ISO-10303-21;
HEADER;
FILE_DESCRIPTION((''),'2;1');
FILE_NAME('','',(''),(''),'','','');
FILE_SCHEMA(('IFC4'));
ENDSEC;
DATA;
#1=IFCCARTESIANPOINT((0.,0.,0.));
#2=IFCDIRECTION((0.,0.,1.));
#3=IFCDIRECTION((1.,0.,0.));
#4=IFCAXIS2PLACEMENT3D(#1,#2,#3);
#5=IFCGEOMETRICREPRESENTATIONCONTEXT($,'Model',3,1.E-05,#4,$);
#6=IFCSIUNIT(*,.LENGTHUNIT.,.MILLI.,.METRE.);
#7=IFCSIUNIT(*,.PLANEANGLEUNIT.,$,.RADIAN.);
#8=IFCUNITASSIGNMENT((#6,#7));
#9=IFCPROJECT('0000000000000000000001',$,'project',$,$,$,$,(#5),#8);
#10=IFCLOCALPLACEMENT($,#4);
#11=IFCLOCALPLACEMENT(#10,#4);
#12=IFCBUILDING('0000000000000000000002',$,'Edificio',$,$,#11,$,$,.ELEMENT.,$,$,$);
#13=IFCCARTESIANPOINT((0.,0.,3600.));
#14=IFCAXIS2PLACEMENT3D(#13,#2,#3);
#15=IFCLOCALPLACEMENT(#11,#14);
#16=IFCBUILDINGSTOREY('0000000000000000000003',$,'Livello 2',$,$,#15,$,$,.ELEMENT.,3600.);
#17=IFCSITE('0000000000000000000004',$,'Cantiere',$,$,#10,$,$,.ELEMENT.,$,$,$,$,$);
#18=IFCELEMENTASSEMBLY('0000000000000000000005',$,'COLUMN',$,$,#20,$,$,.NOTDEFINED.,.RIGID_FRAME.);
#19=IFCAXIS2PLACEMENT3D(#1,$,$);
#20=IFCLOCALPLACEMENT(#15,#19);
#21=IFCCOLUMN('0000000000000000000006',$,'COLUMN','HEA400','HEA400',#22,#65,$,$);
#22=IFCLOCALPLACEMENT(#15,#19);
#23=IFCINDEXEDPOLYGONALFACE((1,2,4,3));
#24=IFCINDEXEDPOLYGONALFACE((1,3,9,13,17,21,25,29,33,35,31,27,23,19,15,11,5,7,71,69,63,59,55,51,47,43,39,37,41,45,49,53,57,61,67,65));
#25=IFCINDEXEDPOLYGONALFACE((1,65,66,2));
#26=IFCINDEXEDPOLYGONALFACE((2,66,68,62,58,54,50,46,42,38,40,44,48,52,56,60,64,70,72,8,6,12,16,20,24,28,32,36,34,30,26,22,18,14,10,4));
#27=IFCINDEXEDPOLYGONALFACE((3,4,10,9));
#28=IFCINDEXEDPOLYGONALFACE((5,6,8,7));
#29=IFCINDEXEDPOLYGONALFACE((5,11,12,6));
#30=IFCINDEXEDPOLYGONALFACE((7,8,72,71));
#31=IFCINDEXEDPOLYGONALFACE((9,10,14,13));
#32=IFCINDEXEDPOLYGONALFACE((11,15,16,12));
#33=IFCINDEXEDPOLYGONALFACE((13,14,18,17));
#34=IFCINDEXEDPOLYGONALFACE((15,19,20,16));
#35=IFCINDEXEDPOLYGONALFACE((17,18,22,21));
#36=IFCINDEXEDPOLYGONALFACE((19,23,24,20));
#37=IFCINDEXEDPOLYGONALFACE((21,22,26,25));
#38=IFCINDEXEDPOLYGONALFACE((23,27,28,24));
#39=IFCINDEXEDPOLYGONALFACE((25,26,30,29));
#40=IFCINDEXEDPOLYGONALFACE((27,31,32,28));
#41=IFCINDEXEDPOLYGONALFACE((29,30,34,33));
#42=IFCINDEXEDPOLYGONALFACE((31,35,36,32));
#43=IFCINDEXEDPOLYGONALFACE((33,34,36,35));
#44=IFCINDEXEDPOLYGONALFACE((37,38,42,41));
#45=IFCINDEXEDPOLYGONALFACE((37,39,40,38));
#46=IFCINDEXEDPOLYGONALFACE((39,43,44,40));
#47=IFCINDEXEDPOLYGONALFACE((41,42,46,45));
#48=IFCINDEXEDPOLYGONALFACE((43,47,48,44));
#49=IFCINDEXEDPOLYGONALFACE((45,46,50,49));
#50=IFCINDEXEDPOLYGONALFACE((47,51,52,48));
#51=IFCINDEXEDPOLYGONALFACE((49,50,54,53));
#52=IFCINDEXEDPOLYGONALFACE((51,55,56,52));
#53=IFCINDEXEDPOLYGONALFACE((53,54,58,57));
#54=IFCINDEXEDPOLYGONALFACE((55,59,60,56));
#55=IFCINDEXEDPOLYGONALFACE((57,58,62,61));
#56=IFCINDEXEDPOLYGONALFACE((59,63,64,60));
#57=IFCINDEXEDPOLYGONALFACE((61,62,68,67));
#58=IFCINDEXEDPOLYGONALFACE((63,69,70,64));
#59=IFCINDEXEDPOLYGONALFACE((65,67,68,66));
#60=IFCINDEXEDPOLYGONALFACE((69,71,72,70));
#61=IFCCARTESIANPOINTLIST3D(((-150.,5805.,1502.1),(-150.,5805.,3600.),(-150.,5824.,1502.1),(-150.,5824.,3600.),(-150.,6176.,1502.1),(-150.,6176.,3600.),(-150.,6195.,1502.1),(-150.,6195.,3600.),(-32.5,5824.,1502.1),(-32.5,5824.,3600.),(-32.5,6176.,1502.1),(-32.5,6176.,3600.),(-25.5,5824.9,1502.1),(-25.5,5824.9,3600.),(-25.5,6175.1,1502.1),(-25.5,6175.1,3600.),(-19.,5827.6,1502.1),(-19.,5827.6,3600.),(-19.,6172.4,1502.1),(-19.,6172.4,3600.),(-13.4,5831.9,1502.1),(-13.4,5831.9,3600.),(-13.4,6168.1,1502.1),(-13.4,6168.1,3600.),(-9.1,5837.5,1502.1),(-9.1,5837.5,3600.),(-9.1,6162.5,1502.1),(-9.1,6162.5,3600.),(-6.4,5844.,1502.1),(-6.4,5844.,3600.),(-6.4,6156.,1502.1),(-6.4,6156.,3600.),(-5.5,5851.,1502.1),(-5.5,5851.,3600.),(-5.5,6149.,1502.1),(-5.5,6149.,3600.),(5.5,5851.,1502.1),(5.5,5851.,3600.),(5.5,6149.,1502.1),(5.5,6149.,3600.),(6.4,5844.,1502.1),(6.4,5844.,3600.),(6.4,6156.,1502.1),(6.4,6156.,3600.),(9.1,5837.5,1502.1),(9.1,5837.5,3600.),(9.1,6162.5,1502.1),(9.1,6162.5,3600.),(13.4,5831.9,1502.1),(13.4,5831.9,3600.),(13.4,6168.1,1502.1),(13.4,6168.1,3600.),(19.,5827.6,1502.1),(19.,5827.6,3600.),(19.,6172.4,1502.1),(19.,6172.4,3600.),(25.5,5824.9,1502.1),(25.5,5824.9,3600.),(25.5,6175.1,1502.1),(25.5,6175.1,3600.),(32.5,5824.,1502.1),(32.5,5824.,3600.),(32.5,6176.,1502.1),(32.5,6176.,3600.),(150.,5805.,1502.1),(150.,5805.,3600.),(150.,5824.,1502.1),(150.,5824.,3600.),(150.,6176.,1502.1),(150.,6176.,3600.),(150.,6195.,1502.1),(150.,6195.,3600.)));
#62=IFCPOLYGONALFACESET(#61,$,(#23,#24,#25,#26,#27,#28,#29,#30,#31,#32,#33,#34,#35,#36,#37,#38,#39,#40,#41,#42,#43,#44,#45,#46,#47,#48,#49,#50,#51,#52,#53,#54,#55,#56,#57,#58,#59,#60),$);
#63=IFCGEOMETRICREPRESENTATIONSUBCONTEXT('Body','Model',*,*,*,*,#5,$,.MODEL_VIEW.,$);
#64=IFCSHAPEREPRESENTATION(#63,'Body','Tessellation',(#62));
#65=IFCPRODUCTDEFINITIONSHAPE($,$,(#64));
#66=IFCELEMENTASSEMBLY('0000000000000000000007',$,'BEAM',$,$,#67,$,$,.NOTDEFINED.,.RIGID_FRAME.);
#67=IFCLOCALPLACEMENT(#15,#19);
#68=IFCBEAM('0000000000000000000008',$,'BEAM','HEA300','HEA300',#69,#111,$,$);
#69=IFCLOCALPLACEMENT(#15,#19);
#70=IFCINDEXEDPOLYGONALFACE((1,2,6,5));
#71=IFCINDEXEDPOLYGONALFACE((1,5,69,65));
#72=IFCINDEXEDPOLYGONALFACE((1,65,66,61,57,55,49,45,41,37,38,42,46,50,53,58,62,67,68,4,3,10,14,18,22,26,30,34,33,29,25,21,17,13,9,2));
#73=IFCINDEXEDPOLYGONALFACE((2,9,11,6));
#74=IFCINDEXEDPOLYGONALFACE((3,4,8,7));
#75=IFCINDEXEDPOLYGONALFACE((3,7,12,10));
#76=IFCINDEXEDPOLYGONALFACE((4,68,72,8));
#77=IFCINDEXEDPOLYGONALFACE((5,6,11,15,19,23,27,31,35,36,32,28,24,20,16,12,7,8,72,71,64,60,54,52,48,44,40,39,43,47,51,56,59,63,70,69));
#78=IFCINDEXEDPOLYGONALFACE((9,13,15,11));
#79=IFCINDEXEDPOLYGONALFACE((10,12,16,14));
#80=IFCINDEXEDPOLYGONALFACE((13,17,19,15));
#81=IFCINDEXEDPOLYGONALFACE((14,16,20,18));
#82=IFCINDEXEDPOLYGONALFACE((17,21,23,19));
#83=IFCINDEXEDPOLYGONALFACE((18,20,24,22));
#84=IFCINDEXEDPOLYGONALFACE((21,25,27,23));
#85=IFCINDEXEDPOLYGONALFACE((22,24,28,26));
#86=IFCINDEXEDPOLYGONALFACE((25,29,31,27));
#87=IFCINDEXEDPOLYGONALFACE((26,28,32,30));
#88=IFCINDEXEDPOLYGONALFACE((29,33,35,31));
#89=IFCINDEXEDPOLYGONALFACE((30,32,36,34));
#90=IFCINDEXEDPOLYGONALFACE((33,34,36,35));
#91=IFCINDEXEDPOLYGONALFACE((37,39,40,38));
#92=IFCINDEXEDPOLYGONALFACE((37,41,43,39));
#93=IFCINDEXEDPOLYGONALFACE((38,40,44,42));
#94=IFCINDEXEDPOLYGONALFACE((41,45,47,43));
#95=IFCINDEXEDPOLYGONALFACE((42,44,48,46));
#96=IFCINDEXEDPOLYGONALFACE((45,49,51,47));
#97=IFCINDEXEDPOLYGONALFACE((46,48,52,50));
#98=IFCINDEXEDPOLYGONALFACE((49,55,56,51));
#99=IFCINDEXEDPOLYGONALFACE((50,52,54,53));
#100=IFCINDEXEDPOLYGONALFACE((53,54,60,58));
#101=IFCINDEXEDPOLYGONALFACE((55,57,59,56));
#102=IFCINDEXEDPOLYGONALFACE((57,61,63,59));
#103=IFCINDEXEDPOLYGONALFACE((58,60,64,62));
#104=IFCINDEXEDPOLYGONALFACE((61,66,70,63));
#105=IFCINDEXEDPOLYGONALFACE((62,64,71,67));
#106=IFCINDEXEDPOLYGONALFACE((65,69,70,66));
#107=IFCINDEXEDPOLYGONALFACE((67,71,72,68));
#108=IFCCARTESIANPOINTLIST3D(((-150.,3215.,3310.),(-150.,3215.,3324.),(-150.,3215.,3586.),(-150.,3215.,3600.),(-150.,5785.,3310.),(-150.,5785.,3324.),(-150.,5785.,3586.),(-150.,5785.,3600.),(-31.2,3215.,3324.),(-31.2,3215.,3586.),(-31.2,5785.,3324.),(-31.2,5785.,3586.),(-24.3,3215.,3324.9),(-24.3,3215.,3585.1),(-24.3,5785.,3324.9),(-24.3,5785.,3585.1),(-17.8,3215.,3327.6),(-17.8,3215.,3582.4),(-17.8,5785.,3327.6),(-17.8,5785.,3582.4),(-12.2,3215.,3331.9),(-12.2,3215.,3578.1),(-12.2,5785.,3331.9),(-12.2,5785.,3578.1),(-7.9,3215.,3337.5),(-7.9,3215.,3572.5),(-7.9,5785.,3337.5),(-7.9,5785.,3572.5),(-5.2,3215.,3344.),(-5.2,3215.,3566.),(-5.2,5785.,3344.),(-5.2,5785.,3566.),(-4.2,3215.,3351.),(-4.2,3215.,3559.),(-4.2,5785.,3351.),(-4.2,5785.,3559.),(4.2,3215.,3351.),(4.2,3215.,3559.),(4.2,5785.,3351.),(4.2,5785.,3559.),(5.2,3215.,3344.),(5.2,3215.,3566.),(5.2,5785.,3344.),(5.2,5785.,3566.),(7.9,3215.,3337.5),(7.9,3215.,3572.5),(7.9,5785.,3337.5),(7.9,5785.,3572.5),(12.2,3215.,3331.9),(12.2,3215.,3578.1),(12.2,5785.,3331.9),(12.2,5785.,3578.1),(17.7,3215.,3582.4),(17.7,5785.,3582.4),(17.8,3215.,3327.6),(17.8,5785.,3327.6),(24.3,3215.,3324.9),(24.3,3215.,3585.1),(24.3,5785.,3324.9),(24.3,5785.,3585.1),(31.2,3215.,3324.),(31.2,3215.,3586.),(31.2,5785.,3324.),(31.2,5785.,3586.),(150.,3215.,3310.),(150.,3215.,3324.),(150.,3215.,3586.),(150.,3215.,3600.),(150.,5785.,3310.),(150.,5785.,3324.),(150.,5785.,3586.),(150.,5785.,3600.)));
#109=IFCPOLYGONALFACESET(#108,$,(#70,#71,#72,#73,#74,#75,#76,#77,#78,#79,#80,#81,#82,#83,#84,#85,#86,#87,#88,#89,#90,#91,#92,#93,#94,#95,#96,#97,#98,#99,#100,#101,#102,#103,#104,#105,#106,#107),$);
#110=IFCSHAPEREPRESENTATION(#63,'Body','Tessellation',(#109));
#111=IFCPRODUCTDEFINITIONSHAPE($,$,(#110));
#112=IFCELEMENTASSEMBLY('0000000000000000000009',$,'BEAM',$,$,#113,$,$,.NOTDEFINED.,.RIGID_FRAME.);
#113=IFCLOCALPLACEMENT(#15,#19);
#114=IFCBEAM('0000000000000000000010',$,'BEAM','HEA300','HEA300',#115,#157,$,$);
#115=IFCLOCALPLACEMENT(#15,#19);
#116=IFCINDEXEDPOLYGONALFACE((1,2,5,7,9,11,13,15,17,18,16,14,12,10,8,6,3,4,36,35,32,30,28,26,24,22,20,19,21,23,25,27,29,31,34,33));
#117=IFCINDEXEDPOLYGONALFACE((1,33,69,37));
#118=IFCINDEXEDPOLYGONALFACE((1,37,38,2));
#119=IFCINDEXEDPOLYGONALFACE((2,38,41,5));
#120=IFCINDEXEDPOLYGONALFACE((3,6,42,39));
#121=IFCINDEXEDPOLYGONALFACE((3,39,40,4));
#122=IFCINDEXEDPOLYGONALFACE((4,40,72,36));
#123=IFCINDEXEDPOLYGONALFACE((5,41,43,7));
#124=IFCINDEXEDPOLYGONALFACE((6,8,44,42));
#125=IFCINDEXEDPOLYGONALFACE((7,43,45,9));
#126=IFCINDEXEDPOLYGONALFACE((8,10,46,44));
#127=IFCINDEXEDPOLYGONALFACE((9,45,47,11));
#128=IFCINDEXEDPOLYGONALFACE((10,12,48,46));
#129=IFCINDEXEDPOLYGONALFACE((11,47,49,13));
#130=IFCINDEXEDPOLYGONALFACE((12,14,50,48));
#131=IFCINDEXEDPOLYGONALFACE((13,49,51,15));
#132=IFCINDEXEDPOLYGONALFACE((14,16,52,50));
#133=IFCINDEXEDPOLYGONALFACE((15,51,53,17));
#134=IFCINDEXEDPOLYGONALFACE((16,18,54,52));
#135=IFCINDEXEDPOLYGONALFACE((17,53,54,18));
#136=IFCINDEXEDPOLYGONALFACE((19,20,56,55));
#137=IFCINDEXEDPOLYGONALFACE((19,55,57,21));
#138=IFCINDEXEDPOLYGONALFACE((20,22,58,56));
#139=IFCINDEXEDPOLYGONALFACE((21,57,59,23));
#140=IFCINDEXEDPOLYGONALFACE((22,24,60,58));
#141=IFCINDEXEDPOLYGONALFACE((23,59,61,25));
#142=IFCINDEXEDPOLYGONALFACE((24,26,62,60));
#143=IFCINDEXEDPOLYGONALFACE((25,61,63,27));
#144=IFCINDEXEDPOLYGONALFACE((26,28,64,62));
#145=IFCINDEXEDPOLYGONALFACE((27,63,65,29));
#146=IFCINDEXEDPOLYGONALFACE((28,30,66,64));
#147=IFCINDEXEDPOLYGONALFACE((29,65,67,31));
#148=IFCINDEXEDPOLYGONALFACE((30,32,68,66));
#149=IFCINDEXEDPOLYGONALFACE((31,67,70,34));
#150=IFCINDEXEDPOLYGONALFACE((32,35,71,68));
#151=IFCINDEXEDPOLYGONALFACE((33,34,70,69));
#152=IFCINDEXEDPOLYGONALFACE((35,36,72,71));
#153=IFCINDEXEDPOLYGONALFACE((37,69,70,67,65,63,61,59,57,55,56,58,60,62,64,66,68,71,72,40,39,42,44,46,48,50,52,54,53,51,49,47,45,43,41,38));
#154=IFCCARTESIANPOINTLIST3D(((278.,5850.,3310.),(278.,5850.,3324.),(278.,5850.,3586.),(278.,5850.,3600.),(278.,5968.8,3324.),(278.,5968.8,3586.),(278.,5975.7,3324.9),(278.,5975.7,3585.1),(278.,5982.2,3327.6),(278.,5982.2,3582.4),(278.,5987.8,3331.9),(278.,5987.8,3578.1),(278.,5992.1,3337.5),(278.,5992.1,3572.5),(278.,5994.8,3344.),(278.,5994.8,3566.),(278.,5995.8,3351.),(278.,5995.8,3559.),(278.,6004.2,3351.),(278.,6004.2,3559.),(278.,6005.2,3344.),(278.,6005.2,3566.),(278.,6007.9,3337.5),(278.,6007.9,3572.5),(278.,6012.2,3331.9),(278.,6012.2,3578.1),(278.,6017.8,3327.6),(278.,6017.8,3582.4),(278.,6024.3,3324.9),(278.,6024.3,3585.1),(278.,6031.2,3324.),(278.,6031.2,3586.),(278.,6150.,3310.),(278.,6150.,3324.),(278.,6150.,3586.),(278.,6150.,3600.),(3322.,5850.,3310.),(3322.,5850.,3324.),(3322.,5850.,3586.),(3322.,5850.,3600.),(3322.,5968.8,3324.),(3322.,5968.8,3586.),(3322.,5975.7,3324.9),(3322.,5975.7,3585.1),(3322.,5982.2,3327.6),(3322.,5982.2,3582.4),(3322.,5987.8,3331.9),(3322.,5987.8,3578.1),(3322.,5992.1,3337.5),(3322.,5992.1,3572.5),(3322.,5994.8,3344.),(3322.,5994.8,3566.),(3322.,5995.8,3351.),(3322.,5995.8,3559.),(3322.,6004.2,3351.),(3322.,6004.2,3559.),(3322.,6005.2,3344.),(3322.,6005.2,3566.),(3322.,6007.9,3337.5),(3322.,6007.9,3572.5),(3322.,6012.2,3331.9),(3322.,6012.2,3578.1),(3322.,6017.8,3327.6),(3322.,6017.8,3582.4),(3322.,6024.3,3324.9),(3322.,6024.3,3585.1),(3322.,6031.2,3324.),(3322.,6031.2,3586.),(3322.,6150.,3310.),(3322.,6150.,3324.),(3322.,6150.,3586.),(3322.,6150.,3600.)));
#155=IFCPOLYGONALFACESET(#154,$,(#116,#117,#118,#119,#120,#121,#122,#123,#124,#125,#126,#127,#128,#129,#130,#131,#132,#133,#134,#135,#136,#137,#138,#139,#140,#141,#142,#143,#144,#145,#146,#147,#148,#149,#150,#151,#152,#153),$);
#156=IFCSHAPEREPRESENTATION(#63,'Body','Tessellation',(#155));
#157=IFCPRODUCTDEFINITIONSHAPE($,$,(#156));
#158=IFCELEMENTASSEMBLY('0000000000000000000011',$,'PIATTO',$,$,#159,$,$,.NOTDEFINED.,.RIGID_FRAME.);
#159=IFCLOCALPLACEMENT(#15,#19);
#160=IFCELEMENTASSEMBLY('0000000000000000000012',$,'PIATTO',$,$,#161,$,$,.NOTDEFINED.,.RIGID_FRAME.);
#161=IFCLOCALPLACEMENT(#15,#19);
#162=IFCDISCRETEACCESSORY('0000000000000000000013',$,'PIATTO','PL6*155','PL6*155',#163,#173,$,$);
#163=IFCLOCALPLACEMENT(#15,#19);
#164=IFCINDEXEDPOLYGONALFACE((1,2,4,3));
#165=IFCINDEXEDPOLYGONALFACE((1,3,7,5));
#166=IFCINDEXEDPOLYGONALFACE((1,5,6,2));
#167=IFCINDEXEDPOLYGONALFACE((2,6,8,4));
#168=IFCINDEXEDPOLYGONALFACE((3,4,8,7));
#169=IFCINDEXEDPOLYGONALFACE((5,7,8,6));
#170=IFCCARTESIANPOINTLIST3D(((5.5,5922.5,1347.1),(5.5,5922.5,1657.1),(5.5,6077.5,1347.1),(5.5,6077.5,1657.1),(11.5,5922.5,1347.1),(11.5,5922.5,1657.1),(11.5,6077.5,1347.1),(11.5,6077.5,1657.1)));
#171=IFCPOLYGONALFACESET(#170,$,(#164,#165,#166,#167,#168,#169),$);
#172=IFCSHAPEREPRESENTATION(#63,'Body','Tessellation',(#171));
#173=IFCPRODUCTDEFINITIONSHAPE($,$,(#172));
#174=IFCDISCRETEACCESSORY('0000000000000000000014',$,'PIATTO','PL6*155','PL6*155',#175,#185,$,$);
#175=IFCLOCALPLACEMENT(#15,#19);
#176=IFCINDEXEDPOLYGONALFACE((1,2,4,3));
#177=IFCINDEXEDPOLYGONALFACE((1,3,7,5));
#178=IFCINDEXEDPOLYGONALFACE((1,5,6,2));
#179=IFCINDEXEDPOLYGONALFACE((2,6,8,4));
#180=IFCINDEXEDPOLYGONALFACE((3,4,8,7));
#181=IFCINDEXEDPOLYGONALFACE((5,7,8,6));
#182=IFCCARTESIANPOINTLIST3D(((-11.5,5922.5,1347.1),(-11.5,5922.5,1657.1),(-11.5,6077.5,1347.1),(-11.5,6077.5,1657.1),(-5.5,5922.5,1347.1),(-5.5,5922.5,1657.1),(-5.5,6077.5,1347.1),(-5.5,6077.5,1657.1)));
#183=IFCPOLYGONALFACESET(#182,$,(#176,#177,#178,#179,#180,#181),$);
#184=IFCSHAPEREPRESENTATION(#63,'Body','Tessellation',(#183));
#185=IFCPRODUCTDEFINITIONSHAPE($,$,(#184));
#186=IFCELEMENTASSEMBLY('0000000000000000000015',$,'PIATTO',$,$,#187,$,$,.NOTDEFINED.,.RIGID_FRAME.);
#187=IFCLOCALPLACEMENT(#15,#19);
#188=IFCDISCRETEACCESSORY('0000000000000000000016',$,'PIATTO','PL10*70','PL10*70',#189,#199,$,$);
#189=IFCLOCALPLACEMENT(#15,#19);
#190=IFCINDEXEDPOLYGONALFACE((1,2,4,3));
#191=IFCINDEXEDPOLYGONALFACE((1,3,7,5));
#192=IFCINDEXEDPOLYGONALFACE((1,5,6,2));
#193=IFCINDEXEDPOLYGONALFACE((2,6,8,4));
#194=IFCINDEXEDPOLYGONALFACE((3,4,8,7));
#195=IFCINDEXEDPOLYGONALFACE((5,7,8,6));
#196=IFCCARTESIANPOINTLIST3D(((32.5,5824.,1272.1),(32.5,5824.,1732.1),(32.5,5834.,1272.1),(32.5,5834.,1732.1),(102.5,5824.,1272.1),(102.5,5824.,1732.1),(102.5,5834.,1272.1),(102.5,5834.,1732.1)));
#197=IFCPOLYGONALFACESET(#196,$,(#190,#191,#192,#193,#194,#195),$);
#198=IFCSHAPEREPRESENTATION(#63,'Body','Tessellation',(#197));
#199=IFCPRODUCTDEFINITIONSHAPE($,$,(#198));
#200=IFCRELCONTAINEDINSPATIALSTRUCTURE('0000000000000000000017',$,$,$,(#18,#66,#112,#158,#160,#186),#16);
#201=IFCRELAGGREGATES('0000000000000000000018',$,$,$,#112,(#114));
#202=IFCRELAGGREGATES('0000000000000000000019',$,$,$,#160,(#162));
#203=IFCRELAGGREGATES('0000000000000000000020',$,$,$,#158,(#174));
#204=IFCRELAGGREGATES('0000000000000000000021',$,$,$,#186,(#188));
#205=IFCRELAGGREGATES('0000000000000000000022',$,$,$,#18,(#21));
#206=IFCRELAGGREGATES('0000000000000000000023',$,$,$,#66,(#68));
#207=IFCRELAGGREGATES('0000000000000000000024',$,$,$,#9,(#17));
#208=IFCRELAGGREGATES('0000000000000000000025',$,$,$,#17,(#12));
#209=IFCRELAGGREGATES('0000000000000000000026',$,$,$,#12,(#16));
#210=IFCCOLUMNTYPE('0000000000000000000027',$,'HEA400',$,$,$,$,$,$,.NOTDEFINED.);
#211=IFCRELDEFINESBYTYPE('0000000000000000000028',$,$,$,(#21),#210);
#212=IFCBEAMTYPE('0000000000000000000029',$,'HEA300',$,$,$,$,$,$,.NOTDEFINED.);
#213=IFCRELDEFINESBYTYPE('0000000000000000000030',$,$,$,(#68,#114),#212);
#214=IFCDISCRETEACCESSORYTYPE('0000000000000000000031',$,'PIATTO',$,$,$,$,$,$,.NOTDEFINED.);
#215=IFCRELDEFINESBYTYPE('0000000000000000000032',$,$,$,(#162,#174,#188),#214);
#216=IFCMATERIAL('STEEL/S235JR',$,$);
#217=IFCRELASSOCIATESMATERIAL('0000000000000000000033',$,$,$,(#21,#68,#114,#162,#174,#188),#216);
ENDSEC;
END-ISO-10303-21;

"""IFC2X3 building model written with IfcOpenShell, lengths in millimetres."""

from ifc_helpers import new_model, si_unit, frame, origin_with_axes, origin_2d_with_axis, place, context, subcontext, project, spatial, polyline, i_section, outline, extrude, clip, halfspace, material, type_object, element, aggregate, save


model = new_model("IFC2X3")

# Units and contexts
model_context = context("Model", 3, precision=1e-05, world=origin_with_axes())
body_context = subcontext(model_context, "Body", "Model", "MODEL_VIEW")
ifc_project = project(units=[si_unit("LENGTHUNIT", "METRE", prefix="MILLI"), si_unit("PLANEANGLEUNIT", "RADIAN")], contexts=[model_context])

# Site, building, storey
site_placement = place(None, origin_with_axes())
site = spatial("IfcSite", under=ifc_project, at=site_placement, Name="Cantiere", CompositionType="ELEMENT")
building_placement = place(site_placement, origin_with_axes())
building = spatial("IfcBuilding", under=site, at=building_placement, Name="Edificio", CompositionType="ELEMENT")
storey_placement = place(building_placement, frame((0.0, 0.0, 3600.0), z_axis=(0.0, 0.0, 1.0), x_axis=(1.0, 0.0, 0.0)))
storey = spatial("IfcBuildingStorey", under=building, at=storey_placement, Name="Livello 2", CompositionType="ELEMENT", Elevation=3600.0)

# Element assembly, column
assembly_1_placement = place(storey_placement, origin_with_axes())
assembly_1 = element("IfcElementAssembly", 1, at=assembly_1_placement, inside=storey, Name="COLUMN", AssemblyPlace="NOTDEFINED", PredefinedType="RIGID_FRAME")
ifc_material_1 = material(Name="STEEL/S235JR")
column_type = type_object("IfcColumnType", Name="HEA400", PredefinedType="NOTDEFINED")
column_placement = place(assembly_1_placement, frame((0.0, 6000.0, 1502.1), z_axis=(0.0, 0.0, 1.0), x_axis=(0.0, 1.0, 0.0)))
column = element("IfcColumn", 2, at=column_placement, type_object=column_type, material=ifc_material_1, Name="COLUMN", Description="HEA400", ObjectType="HEA400", context=body_context, shape_type="Clipping", body=[
    clip(extrude(i_section(OverallWidth=300.0, OverallDepth=390.0, WebThickness=11.0, FlangeThickness=19.0, FilletRadius=27.0, at=origin_2d_with_axis()), frame((0.0, 0.0, 2097.9), z_axis=(0.0, 0.0, -1.0), x_axis=(0.0, 1.0, 0.0)), (0.0, 0.0, 1.0), 2097.9), halfspace(frame((1000.0, 0.0, 0.0), z_axis=(0.0, 0.0, -1.0), x_axis=(0.0, 1.0, 0.0)), False)),
])

# Element assemblies, beams
assembly_2_placement = place(storey_placement, origin_with_axes())
assembly_2 = element("IfcElementAssembly", 3, at=assembly_2_placement, inside=storey, Name="BEAM", AssemblyPlace="NOTDEFINED", PredefinedType="RIGID_FRAME")
beam_type = type_object("IfcBeamType", Name="HEA300", PredefinedType="NOTDEFINED")
beam_1_placement = place(assembly_2_placement, frame((0.0, 6000.0, 3455.0), z_axis=(0.0, 0.0, 1.0), x_axis=(0.0, -1.0, 0.0)))
beam_1 = element("IfcBeam", 4, at=beam_1_placement, type_object=beam_type, material=ifc_material_1, Name="BEAM", Description="HEA300", ObjectType="HEA300", context=body_context, shape_type="Clipping", body=[
    clip(clip(extrude(i_section(OverallWidth=300.0, OverallDepth=290.0, WebThickness=8.5, FlangeThickness=14.0, FilletRadius=27.0, at=origin_2d_with_axis()), frame((2785.0, 0.0, 0.0), z_axis=(-1.0, 0.0, 0.0), x_axis=(0.0, -1.0, 0.0)), (0.0, 0.0, 1.0), 2570.0), halfspace(frame((2785.0, 0.0, -145.0), z_axis=(-1.0, 0.0, 0.0), x_axis=(0.0, 1.0, 0.0)), True)), halfspace(frame((215.0, 0.0, -145.0), z_axis=(1.0, 0.0, 0.0), x_axis=(0.0, -1.0, 0.0)), True)),
])
assembly_3_placement = place(storey_placement, origin_with_axes())
assembly_3 = element("IfcElementAssembly", 5, at=assembly_3_placement, inside=storey, Name="BEAM", AssemblyPlace="NOTDEFINED", PredefinedType="RIGID_FRAME")
beam_2_placement = place(assembly_3_placement, frame((0.0, 6000.0, 3455.0), z_axis=(0.0, 0.0, 1.0), x_axis=(1.0, 0.0, 0.0)))
beam_2 = element("IfcBeam", 6, at=beam_2_placement, type_object=beam_type, material=ifc_material_1, Name="BEAM", Description="HEA300", ObjectType="HEA300", context=body_context, shape_type="Clipping", body=[
    clip(clip(extrude(i_section(OverallWidth=300.0, OverallDepth=290.0, WebThickness=8.5, FlangeThickness=14.0, FilletRadius=27.0, at=origin_2d_with_axis()), frame((3322.0, 0.0, 0.0), z_axis=(-1.0, 0.0, 0.0), x_axis=(0.0, -1.0, 0.0)), (0.0, 0.0, 1.0), 3044.0), halfspace(frame((3322.0, -150.0, 0.0), z_axis=(1.0, 0.0, 0.0), x_axis=(0.0, 0.0, 1.0)), False)), halfspace(frame((278.0, 150.0, 0.0), z_axis=(-1.0, 0.0, 0.0), x_axis=(0.0, 0.0, 1.0)), False)),
])
aggregate(assembly_3, [beam_2])

# Element assembly
assembly_4_placement = place(storey_placement, origin_with_axes())
assembly_4 = element("IfcElementAssembly", 7, at=assembly_4_placement, inside=storey, Name="PIATTO", AssemblyPlace="NOTDEFINED", PredefinedType="RIGID_FRAME")

# Element assembly, discrete accessory
assembly_5_placement = place(storey_placement, origin_with_axes())
assembly_5 = element("IfcElementAssembly", 8, at=assembly_5_placement, inside=storey, Name="PIATTO", AssemblyPlace="NOTDEFINED", PredefinedType="RIGID_FRAME")
discrete_accessory_type_1 = type_object("IfcDiscreteAccessoryType", Name="PIATTO")
discrete_accessory_1_placement = place(assembly_5_placement, frame((8.5, 6000.0, 1347.1), z_axis=(-1.0, 0.0, 0.0), x_axis=(0.0, 0.0, 1.0)))
discrete_accessory_1 = element("IfcDiscreteAccessory", 9, at=discrete_accessory_1_placement, type_object=discrete_accessory_type_1, material=ifc_material_1, Name="PIATTO", Description="PL6*155", ObjectType="PL6*155", context=body_context, shape_type="SweptSolid", body=[
    extrude(outline(polyline([(0.0, -77.5), (0.0, 77.5), (310.0, 77.5), (310.0, -77.5), (0.0, -77.5)])), frame((0.0, 0.0, -3.0), z_axis=(0.0, 0.0, 1.0), x_axis=(1.0, 0.0, 0.0)), (0.0, 0.0, 1.0), 6.0),
])
aggregate(assembly_5, [discrete_accessory_1])

# Discrete accessory
discrete_accessory_2_placement = place(assembly_4_placement, frame((-8.5, 6000.0, 1347.1), z_axis=(-1.0, 0.0, 0.0), x_axis=(0.0, 0.0, 1.0)))
discrete_accessory_2 = element("IfcDiscreteAccessory", 10, at=discrete_accessory_2_placement, type_object=discrete_accessory_type_1, material=ifc_material_1, Name="PIATTO", Description="PL6*155", ObjectType="PL6*155", context=body_context, shape_type="SweptSolid", body=[
    extrude(outline(polyline([(0.0, -77.5), (0.0, 77.5), (310.0, 77.5), (310.0, -77.5), (0.0, -77.5)])), frame((0.0, 0.0, -3.0), z_axis=(0.0, 0.0, 1.0), x_axis=(1.0, 0.0, 0.0)), (0.0, 0.0, 1.0), 6.0),
])
aggregate(assembly_4, [discrete_accessory_2])

# Element assembly, discrete accessory
assembly_6_placement = place(storey_placement, origin_with_axes())
assembly_6 = element("IfcElementAssembly", 11, at=assembly_6_placement, inside=storey, Name="PIATTO", AssemblyPlace="NOTDEFINED", PredefinedType="RIGID_FRAME")
discrete_accessory_3_placement = place(assembly_6_placement, frame((67.5, 5829.0, 1732.1), z_axis=(0.0, 1.0, 0.0), x_axis=(0.0, 0.0, -1.0)))
discrete_accessory_3 = element("IfcDiscreteAccessory", 12, at=discrete_accessory_3_placement, type_object=discrete_accessory_type_1, material=ifc_material_1, Name="PIATTO", Description="PL10*70", ObjectType="PL10*70", context=body_context, shape_type="SweptSolid", body=[
    extrude(outline(polyline([(460.0, 35.0), (460.0, -35.0), (0.0, -35.0), (0.0, 35.0), (460.0, 35.0)])), frame((0.0, 0.0, -5.0), z_axis=(0.0, 0.0, 1.0), x_axis=(1.0, 0.0, 0.0)), (0.0, 0.0, 1.0), 10.0),
])

aggregate(assembly_6, [discrete_accessory_3])

aggregate(assembly_1, [column])
aggregate(assembly_2, [beam_1])

save(model, "model.ifc")
